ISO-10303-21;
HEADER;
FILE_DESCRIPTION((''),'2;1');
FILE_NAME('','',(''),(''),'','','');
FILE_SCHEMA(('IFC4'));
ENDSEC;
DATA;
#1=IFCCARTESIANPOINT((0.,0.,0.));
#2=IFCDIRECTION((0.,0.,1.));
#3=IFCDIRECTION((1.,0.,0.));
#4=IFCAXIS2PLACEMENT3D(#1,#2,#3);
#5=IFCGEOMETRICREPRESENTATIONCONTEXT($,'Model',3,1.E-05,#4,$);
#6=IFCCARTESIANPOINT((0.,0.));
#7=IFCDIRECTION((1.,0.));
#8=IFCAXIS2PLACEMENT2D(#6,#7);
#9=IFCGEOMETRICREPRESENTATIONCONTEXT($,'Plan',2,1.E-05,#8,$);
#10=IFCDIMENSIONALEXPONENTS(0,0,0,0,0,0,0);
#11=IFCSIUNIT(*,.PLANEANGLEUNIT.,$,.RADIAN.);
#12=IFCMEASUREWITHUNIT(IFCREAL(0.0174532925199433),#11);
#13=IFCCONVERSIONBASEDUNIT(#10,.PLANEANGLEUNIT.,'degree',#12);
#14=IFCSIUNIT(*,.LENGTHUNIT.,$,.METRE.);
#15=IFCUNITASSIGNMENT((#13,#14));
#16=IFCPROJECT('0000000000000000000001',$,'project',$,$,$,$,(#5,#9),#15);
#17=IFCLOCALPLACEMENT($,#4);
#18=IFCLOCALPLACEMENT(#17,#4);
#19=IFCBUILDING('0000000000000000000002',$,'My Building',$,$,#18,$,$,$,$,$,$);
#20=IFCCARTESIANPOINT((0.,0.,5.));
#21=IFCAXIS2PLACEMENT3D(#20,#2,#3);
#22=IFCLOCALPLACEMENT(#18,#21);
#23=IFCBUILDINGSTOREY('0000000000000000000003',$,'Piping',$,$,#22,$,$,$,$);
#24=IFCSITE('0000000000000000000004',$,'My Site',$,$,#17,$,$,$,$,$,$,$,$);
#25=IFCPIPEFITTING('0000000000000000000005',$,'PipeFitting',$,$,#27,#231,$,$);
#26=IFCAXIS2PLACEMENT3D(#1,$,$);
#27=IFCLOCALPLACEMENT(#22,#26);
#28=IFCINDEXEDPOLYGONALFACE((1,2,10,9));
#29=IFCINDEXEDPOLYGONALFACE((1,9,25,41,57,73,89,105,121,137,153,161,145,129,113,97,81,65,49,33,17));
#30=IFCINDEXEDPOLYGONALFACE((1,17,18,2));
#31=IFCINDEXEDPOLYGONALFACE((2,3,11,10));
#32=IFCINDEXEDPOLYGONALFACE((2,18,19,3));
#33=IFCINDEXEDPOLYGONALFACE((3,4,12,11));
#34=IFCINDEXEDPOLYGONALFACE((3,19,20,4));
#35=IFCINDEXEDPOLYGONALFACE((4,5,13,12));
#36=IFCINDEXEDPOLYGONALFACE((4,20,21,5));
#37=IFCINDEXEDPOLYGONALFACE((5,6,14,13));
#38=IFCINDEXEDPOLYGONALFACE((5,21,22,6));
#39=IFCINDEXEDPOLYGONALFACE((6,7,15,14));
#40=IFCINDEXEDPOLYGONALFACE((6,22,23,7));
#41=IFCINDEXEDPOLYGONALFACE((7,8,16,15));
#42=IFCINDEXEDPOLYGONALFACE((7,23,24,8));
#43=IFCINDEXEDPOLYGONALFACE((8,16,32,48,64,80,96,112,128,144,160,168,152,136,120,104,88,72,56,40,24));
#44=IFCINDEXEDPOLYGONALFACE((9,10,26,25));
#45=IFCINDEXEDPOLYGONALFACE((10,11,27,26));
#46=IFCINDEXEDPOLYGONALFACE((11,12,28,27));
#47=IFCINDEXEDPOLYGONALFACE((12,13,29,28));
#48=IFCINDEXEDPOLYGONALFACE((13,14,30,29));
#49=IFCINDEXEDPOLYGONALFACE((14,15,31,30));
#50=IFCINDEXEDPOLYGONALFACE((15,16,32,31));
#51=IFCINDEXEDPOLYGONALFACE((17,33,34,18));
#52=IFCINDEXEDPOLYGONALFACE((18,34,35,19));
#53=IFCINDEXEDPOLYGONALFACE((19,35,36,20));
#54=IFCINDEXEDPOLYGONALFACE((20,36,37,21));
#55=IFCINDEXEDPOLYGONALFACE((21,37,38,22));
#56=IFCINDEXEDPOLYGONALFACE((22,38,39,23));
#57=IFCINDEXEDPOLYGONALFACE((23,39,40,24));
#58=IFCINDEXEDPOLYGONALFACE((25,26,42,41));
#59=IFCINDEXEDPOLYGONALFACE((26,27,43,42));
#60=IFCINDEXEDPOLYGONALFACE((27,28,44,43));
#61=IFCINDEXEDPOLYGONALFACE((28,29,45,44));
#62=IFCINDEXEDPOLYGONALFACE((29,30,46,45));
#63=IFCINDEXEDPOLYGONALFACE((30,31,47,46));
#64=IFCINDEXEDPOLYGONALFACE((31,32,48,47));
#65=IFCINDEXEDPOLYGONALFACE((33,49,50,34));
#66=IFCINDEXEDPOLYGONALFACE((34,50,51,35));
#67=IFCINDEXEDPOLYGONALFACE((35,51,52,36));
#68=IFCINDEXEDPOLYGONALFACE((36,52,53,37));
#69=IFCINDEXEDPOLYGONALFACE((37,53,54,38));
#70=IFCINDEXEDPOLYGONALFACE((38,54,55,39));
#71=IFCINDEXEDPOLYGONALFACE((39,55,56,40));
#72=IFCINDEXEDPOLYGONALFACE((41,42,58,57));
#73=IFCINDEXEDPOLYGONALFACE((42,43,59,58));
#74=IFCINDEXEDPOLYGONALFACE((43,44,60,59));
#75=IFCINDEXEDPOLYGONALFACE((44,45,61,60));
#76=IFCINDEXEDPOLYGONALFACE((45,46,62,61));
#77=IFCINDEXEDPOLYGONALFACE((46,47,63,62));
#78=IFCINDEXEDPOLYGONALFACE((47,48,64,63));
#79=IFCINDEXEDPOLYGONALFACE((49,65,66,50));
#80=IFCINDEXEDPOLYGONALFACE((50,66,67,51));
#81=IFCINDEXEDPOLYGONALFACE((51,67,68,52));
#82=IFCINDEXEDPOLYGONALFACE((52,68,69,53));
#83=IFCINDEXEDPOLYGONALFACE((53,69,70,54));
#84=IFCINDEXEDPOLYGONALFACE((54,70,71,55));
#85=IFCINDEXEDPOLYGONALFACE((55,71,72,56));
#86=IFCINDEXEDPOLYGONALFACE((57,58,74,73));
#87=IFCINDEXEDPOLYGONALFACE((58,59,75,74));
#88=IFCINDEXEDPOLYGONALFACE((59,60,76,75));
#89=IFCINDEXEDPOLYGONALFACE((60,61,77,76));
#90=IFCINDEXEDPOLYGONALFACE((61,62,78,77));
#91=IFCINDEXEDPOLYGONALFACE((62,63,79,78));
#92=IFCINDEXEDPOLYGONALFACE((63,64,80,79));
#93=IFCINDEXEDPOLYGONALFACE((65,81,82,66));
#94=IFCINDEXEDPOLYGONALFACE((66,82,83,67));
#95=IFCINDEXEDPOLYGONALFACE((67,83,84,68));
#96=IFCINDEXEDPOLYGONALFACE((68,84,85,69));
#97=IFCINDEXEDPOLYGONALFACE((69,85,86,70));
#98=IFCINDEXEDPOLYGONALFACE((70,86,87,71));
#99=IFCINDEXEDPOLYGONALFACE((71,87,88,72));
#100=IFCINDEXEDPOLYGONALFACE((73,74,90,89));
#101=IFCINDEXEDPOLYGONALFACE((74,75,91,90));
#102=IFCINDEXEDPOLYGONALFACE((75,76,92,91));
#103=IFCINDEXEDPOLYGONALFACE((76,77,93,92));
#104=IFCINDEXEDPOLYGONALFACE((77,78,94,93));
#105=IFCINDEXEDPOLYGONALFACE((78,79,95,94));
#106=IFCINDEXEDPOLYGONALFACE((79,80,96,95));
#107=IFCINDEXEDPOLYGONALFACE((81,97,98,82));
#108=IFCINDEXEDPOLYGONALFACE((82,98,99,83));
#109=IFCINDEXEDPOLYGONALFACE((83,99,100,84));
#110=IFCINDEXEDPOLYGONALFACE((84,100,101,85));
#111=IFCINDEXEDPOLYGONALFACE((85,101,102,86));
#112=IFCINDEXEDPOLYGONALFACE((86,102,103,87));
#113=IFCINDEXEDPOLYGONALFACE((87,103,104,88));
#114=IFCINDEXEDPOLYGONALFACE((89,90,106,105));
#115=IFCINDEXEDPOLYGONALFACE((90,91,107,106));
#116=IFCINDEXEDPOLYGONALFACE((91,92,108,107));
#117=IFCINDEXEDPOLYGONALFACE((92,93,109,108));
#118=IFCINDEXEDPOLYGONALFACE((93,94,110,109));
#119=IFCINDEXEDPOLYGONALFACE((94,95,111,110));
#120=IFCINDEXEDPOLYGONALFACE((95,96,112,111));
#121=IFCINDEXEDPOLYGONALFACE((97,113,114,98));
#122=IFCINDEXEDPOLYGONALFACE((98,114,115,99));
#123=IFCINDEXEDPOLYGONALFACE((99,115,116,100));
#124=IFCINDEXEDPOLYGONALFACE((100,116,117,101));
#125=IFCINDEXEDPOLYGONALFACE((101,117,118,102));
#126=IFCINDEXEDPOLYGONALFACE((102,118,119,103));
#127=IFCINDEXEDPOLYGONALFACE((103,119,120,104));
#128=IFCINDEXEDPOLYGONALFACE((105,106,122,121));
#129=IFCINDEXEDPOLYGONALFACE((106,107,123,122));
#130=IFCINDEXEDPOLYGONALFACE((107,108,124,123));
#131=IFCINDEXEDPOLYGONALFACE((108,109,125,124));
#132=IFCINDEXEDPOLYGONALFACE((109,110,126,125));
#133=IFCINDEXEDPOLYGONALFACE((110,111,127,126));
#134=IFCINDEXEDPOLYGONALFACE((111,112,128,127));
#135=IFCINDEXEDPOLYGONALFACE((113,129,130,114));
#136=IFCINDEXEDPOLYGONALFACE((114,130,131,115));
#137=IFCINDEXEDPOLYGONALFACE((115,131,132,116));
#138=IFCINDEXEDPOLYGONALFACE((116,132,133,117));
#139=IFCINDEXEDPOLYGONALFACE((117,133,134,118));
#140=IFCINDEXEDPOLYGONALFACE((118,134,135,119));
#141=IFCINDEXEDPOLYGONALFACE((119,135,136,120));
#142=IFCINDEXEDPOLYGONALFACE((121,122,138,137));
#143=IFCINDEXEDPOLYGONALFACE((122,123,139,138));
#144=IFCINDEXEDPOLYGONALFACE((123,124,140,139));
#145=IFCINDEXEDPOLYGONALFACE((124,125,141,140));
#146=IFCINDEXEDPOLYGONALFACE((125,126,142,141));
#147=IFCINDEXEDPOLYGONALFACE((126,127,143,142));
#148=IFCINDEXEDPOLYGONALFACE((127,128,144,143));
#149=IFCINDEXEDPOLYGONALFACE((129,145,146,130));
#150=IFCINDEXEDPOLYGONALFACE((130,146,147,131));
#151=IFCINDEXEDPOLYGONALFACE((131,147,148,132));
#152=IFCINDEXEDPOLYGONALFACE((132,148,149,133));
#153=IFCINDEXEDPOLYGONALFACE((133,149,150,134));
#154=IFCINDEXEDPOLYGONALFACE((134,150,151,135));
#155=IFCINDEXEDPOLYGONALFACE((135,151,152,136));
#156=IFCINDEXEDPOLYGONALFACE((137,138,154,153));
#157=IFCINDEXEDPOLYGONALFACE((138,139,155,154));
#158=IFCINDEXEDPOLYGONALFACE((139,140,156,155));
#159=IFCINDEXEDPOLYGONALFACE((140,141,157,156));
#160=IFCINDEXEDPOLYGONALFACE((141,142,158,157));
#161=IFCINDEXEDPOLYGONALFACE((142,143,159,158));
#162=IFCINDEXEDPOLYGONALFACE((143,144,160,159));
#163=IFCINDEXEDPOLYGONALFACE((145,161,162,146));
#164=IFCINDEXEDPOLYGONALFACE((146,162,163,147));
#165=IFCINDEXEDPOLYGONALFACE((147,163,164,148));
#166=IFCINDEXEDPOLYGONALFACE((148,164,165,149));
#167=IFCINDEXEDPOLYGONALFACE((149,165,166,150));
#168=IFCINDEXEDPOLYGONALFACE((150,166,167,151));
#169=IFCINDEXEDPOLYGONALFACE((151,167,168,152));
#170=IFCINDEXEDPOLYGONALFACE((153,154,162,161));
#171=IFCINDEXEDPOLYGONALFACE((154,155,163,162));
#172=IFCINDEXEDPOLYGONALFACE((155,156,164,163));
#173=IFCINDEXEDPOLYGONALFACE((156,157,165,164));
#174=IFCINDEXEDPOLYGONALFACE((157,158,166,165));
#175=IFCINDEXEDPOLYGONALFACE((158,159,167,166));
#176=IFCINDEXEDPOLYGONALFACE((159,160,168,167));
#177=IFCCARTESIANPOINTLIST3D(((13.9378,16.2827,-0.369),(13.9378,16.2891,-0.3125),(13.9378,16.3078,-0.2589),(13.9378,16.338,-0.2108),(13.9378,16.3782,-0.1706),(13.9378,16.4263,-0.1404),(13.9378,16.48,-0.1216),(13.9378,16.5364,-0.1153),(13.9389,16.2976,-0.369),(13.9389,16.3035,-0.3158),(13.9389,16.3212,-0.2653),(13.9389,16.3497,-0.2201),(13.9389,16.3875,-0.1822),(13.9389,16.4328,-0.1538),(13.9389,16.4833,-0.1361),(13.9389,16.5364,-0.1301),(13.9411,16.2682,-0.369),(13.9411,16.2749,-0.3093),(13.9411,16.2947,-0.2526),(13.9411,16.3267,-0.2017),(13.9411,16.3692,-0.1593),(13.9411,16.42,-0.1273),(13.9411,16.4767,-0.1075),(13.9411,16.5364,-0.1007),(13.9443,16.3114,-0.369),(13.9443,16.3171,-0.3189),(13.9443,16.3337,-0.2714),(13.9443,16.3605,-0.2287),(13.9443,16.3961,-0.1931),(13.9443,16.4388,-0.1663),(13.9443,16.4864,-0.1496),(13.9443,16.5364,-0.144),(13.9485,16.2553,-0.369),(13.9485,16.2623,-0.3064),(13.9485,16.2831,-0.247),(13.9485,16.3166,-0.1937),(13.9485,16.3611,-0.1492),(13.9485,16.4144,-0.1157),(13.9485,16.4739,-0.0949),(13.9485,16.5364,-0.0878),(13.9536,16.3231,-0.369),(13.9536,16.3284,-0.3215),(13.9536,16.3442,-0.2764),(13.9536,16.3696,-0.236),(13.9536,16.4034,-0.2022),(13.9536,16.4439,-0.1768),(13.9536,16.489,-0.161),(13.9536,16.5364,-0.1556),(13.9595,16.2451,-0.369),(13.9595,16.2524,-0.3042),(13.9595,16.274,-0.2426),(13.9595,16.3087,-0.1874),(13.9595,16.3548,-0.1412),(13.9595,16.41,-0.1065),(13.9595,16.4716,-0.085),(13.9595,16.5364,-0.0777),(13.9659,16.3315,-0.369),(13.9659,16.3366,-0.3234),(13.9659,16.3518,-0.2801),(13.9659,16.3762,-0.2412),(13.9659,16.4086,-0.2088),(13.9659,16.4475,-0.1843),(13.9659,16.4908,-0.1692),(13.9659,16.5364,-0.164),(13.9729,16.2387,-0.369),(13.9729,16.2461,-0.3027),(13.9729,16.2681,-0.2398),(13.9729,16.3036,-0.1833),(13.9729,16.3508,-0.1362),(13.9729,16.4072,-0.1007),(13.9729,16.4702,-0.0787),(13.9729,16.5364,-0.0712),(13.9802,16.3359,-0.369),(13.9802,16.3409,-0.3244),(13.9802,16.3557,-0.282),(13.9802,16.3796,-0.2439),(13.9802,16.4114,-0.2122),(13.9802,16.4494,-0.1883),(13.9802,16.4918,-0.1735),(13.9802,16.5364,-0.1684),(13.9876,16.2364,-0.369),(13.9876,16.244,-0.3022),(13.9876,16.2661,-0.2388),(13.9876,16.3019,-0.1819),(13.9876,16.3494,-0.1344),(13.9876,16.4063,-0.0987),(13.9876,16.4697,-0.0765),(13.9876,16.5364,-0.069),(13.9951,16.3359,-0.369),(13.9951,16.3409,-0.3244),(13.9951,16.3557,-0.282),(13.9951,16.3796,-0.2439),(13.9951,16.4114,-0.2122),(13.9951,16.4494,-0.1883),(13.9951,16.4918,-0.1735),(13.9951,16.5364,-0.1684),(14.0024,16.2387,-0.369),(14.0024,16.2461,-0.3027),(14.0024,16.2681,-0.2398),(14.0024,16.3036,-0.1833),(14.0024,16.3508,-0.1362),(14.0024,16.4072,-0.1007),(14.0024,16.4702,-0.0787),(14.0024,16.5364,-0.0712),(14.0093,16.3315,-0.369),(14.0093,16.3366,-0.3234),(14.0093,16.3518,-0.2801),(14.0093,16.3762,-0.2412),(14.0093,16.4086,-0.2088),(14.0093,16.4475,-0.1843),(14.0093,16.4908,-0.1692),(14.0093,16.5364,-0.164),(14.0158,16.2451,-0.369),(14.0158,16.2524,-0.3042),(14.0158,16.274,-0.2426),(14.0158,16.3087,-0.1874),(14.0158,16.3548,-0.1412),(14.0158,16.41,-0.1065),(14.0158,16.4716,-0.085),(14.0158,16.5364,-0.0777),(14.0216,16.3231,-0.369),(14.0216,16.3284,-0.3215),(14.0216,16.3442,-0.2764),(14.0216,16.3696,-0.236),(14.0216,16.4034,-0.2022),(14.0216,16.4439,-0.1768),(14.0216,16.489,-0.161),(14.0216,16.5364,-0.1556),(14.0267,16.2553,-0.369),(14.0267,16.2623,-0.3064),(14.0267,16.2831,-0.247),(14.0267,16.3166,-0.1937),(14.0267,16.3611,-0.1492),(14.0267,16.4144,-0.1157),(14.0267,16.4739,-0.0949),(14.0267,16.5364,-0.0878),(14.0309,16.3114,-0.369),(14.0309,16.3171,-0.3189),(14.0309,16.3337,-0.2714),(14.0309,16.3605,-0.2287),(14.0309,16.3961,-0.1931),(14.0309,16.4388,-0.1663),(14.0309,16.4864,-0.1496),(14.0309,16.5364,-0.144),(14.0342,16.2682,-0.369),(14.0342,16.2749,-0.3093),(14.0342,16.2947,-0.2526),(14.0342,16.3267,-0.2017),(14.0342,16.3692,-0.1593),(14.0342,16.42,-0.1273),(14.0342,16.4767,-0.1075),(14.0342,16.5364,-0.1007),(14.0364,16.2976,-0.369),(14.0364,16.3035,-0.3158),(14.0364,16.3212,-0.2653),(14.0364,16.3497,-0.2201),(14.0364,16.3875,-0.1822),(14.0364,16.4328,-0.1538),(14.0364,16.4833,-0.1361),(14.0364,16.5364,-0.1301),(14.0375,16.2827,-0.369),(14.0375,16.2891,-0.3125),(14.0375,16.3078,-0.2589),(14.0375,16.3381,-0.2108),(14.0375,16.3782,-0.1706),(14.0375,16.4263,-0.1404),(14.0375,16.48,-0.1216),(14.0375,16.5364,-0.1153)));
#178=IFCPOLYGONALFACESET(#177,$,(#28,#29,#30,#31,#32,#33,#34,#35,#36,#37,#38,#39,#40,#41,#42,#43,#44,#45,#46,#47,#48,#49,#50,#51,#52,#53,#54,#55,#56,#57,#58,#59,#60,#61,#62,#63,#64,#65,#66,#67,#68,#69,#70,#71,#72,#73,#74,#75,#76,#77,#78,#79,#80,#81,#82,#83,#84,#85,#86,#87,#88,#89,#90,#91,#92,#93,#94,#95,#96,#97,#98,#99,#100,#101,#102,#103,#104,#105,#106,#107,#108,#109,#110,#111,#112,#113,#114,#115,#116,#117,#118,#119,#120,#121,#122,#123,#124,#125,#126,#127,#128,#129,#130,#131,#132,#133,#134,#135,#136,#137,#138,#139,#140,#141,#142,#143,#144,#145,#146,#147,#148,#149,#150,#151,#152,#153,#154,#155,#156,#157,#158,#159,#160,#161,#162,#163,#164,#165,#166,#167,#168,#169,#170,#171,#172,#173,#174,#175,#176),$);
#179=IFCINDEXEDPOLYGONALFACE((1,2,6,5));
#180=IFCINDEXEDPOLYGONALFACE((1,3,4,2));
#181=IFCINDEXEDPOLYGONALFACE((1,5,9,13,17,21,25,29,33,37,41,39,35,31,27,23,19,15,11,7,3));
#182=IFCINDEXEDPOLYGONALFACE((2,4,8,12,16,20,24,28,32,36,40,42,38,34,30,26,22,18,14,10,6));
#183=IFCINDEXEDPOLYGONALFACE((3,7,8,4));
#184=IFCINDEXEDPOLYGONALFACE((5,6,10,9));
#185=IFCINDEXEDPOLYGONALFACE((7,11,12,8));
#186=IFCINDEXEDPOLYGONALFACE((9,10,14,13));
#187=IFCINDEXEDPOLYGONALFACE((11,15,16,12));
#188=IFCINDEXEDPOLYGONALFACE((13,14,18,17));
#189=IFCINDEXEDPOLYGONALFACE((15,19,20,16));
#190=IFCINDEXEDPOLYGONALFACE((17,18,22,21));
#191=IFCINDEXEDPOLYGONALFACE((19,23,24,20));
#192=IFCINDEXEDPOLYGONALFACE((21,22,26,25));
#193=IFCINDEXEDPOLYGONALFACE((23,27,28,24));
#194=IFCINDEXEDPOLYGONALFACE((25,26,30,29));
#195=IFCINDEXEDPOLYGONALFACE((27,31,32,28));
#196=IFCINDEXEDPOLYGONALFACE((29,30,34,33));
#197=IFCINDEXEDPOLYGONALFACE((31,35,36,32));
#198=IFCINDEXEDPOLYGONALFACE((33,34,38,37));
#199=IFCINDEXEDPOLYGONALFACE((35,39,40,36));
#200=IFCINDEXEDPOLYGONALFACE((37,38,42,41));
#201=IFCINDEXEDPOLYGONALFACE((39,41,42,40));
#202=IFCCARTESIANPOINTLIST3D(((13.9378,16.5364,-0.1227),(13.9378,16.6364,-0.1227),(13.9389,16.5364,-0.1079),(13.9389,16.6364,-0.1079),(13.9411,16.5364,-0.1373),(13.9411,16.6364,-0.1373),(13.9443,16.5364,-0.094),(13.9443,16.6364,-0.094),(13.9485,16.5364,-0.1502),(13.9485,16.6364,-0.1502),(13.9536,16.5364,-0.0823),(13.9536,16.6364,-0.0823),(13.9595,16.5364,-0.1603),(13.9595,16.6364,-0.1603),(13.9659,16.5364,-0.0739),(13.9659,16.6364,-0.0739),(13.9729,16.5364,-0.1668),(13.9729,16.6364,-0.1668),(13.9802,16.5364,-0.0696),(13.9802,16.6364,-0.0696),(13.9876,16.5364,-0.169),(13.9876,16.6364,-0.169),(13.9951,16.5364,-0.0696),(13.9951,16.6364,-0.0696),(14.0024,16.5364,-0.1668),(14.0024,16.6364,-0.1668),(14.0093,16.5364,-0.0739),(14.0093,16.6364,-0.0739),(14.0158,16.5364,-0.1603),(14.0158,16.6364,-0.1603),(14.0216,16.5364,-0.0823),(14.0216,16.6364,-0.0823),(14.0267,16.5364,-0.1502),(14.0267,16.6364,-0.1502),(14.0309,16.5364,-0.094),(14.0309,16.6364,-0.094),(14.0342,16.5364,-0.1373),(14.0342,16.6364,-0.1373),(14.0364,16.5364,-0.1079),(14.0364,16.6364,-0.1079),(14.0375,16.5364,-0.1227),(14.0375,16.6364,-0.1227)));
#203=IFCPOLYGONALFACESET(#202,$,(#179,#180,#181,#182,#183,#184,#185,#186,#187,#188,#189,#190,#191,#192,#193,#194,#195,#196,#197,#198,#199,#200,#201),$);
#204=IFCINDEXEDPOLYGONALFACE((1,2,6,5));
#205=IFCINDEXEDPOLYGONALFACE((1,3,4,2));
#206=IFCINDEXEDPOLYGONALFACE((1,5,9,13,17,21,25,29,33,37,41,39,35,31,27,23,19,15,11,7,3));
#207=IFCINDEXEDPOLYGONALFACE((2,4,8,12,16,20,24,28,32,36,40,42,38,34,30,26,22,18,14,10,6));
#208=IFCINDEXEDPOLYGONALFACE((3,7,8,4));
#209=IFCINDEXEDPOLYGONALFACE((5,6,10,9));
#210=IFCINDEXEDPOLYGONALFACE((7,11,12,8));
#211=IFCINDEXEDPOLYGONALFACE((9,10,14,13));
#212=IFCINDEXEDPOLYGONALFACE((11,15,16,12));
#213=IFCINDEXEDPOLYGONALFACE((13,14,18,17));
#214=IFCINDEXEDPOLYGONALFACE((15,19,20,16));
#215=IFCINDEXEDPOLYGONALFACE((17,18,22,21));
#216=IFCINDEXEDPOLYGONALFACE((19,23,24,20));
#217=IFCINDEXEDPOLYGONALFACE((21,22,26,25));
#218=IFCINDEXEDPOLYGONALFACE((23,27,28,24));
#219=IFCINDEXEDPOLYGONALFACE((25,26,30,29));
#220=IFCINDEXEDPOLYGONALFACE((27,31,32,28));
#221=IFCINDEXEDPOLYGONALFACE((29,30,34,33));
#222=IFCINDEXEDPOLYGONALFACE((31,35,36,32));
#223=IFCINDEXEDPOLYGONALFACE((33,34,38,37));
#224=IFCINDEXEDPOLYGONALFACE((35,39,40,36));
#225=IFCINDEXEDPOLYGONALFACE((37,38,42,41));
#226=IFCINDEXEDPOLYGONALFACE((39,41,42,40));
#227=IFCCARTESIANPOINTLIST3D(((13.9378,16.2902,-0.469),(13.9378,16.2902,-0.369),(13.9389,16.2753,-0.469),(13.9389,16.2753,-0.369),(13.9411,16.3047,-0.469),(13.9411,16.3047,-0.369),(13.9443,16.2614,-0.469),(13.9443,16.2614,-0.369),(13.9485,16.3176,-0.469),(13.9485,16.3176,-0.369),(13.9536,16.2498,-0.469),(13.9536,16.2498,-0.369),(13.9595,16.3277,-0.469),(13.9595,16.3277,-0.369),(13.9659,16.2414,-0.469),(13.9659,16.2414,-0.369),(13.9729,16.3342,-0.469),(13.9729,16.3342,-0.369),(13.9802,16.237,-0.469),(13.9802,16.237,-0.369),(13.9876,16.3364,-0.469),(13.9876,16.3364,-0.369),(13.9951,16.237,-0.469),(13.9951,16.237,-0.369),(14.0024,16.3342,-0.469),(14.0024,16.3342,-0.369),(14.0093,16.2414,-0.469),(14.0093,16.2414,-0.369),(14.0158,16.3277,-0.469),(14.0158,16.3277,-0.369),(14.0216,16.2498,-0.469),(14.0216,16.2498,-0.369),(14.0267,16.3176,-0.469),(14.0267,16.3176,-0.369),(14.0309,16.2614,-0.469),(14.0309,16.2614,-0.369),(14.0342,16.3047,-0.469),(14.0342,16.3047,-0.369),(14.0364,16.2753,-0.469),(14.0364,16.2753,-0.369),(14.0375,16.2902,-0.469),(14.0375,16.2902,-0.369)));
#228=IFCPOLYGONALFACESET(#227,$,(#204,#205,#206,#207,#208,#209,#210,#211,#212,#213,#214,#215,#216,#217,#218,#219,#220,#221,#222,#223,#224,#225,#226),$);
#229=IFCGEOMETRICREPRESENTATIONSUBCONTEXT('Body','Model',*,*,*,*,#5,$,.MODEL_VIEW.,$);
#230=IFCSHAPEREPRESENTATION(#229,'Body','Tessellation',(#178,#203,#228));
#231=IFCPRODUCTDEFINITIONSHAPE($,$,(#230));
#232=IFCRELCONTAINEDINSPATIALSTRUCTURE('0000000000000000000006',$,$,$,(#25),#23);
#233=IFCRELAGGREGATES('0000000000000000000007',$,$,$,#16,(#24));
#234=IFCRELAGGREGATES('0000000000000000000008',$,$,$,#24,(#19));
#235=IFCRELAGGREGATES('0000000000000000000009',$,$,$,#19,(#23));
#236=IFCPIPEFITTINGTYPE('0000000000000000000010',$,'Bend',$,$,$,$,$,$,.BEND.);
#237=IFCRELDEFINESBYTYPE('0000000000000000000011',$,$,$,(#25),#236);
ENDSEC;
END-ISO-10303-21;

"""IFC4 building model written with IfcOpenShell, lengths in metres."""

from ifc_helpers import new_model, entity, si_unit, converted_unit, frame, origin_with_axes, origin_2d_with_axis, place, context, subcontext, project, spatial, circle, extrude, source, transform, mapped, type_object, type_shapes, element, save


model = new_model("IFC4")

# Units and contexts
model_context = context("Model", 3, precision=1e-05, world=origin_with_axes())
plan_context = context("Plan", 2, precision=1e-05, world=origin_2d_with_axis())
body_context = subcontext(model_context, "Body", "Model", "MODEL_VIEW")
ifc_project = project(units=[converted_unit("PLANEANGLEUNIT", "degree", entity("IfcReal", 0.0174532925199433), si_unit("PLANEANGLEUNIT", "RADIAN"), dimensions=[0, 0, 0, 0, 0, 0, 0]), si_unit("LENGTHUNIT", "METRE")], contexts=[model_context, plan_context])

# Site, building, storey
site_placement = place(None, origin_with_axes())
site = spatial("IfcSite", under=ifc_project, at=site_placement, Name="My Site")
building_placement = place(site_placement, origin_with_axes())
building = spatial("IfcBuilding", under=site, at=building_placement, Name="My Building")
storey_placement = place(building_placement, frame((0.0, 0.0, 5.0), z_axis=(0.0, 0.0, 1.0), x_axis=(1.0, 0.0, 0.0)))
storey = spatial("IfcBuildingStorey", under=building, at=storey_placement, Name="Piping")

# Pipe fitting
pipe_fitting_type_1 = type_object("IfcPipeFittingType", Name="Bend", PredefinedType="BEND")
shared_shape = source(origin_with_axes(), body_context, "Body", "SolidModel", [
    entity("IfcSweptDiskSolid", entity("IfcIndexedPolyCurve", entity("IfcCartesianPointList3D", [[0.0, 0.0, -0.1], [0.0732, 0.0, -0.2768], [0.25, 0.0, -0.35]]), [entity("IfcArcIndex", [1, 2, 3])]), 0.05),
    extrude(circle(Radius=0.05), origin_with_axes(), (0.0, 0.0, -1.0), 0.1),
    extrude(circle(Radius=0.05), frame((0.25, 0.0, -0.35), z_axis=(1.0, 0.0, 0.0), x_axis=(0.0, 0.0, 1.0)), (0.0, 0.0, 1.0), 0.1),
])
type_shapes(pipe_fitting_type_1, [shared_shape])
for number, where, z_axis, x_axis, name in (
    (1, (13.9876, 16.6364, -0.119), (-0.00006, 1.0, 0.0), (0.0, 0.0, -1.0), "PipeFitting"),
):
    element("IfcPipeFitting", number, at=place(storey_placement, frame(where, z_axis=z_axis, x_axis=x_axis)), inside=storey, type_object=pipe_fitting_type_1, Name=name, context=body_context, shape_type="MappedRepresentation", body=[
        mapped(shared_shape, transform((0.0, 0.0, 0.0), x_axis=(1.0, 0.0, 0.0), y_axis=(0.0, 1.0, 0.0), z_axis=(0.0, 0.0, 1.0), scale=1.0)),
    ])

save(model, "model.ifc")
